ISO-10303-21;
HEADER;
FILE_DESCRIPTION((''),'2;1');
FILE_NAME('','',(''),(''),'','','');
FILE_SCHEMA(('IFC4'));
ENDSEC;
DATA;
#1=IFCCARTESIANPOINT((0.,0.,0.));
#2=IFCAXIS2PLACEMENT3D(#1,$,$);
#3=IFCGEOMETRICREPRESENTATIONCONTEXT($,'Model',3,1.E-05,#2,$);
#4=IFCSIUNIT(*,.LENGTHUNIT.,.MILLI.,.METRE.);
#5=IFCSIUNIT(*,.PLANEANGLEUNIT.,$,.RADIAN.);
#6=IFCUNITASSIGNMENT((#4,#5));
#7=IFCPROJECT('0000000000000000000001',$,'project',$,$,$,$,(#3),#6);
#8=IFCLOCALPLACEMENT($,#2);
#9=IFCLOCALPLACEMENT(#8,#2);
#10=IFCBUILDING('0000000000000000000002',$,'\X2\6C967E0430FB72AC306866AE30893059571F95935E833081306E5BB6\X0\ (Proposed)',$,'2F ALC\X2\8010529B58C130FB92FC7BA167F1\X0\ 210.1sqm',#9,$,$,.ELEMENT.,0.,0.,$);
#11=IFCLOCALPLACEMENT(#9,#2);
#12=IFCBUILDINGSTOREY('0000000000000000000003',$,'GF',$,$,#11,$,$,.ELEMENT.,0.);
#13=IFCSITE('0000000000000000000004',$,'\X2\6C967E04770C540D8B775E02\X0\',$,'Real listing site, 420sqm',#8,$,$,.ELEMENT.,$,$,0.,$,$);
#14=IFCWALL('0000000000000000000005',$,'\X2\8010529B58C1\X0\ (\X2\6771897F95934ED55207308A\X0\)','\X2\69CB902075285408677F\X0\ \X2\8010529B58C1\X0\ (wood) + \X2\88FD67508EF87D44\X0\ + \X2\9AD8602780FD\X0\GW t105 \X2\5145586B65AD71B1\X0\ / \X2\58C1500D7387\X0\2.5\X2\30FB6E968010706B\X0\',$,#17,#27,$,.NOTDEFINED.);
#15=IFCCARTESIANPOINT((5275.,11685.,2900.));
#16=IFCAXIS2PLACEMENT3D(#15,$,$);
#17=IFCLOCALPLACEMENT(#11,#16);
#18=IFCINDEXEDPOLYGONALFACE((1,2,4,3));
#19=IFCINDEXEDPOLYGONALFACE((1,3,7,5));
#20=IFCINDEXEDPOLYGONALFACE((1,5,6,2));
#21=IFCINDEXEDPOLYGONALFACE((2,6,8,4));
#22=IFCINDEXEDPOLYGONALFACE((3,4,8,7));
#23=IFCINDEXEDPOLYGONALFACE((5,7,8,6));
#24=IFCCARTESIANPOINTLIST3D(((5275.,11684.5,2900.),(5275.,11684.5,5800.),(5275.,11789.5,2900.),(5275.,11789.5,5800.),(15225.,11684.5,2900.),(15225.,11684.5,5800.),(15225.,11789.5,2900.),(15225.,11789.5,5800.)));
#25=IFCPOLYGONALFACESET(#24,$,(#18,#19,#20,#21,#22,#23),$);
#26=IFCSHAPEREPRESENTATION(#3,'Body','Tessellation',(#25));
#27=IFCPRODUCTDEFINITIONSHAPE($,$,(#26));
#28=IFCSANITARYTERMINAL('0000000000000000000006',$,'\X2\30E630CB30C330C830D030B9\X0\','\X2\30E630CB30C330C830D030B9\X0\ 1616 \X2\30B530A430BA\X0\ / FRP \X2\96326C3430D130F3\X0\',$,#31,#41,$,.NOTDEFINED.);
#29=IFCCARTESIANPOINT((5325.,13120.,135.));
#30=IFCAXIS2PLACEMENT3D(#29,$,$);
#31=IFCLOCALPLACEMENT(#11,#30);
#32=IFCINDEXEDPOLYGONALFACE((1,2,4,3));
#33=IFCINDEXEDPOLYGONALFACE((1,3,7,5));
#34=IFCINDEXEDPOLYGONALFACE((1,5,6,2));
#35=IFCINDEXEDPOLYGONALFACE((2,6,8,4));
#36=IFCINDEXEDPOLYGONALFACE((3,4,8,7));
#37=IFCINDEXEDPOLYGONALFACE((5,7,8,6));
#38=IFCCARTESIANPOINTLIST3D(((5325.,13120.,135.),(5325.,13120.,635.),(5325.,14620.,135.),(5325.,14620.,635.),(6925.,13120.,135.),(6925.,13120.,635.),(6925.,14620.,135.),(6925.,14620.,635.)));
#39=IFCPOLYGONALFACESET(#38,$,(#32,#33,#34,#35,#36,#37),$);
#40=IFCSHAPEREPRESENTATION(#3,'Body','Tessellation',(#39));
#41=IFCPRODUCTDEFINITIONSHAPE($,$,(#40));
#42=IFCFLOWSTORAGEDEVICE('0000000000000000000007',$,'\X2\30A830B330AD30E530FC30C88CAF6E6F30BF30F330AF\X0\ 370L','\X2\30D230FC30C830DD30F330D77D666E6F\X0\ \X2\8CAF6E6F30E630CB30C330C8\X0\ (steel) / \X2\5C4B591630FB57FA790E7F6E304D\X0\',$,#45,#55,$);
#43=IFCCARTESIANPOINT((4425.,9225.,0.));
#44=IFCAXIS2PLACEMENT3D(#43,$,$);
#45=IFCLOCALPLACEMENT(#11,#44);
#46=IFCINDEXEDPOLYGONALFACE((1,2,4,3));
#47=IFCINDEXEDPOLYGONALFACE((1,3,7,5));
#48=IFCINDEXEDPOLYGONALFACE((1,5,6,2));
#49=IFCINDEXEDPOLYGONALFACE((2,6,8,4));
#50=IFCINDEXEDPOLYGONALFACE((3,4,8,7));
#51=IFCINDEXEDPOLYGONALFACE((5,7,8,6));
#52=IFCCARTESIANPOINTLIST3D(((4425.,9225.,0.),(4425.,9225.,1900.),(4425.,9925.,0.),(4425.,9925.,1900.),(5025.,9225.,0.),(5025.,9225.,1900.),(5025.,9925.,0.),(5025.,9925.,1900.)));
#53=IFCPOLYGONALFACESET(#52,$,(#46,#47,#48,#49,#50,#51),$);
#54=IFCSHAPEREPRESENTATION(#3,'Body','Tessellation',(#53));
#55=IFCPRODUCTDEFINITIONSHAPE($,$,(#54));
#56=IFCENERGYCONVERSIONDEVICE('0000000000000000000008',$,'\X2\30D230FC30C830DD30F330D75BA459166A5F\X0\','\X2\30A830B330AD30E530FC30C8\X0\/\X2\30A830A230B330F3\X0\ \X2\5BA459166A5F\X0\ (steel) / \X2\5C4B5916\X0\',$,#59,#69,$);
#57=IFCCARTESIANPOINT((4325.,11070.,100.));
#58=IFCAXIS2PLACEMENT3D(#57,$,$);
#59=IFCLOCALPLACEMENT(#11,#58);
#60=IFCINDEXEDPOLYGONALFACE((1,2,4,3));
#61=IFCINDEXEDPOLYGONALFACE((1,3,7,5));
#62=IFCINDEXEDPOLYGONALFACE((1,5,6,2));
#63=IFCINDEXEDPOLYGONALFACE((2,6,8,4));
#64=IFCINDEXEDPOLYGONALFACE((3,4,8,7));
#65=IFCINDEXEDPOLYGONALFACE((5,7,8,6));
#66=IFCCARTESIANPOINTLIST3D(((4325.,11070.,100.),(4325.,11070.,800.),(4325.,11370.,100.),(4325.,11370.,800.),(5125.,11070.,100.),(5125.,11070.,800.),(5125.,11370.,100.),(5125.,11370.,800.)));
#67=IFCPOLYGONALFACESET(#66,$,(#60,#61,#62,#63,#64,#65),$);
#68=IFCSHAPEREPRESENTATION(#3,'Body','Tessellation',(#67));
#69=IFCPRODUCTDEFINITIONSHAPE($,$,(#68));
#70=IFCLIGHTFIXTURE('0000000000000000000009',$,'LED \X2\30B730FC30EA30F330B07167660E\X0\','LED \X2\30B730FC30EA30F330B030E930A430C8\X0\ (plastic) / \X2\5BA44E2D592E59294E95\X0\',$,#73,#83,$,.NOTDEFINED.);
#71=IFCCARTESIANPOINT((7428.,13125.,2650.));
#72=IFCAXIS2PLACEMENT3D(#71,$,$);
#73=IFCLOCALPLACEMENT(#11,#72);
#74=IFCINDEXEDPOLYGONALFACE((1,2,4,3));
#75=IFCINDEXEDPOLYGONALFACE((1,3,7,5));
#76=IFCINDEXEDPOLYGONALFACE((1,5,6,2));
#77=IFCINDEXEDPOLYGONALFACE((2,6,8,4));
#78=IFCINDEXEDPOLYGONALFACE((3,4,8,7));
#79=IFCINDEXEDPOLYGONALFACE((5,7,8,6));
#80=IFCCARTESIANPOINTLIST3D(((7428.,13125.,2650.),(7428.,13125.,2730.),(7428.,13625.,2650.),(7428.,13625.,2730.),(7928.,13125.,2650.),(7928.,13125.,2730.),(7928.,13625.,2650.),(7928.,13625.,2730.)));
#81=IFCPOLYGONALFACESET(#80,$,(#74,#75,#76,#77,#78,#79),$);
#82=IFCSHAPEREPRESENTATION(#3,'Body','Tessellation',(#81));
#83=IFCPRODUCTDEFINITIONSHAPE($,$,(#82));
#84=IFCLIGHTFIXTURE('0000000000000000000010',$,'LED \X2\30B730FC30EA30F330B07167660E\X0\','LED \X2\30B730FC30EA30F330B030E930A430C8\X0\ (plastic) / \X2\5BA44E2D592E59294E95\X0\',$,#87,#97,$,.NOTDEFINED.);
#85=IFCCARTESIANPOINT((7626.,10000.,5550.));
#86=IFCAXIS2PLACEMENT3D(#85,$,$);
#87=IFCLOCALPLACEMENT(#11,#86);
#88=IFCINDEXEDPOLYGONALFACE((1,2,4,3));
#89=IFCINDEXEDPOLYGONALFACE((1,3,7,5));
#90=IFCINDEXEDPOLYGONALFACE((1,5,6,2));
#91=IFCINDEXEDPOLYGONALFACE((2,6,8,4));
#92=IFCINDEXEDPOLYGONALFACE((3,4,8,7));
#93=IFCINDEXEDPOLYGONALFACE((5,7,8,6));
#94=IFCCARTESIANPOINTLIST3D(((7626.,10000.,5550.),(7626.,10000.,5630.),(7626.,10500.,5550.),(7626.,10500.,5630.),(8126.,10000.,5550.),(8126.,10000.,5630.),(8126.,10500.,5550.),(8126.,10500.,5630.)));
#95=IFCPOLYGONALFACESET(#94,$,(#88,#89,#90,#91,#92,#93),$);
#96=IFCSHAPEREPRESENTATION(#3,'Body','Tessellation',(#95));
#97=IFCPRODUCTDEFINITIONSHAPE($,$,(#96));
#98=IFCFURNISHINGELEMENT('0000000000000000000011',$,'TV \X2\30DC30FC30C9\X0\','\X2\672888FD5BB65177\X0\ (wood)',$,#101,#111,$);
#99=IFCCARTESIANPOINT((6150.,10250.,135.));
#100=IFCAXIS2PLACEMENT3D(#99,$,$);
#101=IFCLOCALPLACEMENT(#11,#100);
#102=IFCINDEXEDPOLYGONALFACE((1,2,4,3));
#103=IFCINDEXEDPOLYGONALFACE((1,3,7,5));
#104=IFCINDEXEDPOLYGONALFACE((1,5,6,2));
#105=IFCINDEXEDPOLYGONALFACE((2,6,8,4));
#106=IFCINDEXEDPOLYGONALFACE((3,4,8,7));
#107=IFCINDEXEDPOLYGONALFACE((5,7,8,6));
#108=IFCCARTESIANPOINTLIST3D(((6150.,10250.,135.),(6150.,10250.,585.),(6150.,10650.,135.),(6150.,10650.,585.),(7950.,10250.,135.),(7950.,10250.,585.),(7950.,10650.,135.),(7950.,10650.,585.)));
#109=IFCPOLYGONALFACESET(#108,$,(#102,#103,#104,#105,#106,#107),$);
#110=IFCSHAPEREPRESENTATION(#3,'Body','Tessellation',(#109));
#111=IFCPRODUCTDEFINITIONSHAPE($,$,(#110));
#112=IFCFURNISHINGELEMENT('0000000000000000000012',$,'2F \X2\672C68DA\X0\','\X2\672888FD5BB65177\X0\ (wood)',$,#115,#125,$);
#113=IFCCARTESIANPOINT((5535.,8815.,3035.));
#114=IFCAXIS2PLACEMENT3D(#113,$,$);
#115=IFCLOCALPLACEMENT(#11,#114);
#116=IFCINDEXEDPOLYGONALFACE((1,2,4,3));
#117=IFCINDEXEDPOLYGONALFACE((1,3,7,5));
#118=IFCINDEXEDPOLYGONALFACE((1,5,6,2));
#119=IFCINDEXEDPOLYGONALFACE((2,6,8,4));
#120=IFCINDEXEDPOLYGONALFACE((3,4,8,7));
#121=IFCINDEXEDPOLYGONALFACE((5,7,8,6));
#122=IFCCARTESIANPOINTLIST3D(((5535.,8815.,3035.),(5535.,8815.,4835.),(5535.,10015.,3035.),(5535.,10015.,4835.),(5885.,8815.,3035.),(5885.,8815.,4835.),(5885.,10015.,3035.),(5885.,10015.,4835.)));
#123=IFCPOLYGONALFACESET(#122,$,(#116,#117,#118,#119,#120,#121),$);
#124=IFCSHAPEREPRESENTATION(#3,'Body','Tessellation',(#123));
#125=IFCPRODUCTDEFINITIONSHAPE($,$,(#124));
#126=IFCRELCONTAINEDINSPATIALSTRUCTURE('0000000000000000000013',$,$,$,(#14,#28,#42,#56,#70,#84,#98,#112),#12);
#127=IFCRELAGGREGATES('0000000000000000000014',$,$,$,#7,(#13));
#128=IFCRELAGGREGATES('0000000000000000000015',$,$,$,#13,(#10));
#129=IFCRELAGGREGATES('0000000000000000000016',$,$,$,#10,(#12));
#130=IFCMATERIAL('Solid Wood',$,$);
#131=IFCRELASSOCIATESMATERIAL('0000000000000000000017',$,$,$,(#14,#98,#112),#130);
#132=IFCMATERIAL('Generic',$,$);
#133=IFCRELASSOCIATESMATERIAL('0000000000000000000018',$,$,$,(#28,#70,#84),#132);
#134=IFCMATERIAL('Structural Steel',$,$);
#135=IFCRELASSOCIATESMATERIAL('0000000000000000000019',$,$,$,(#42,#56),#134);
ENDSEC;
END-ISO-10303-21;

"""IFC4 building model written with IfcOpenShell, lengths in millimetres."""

from ifc_helpers import new_model, si_unit, frame, frame_2d, origin, place, context, project, spatial, rectangle, extrude, material, element, save


model = new_model("IFC4")

# Units and contexts
model_context = context("Model", 3, precision=1e-05, world=origin())
ifc_project = project(units=[si_unit("LENGTHUNIT", "METRE", prefix="MILLI"), si_unit("PLANEANGLEUNIT", "RADIAN")], contexts=[model_context])

# Site, building, storey
site_placement = place(None, origin())
site = spatial("IfcSite", under=ifc_project, at=site_placement, Name="沖縄県名護市", ObjectType="Real listing site, 420sqm", CompositionType="ELEMENT", RefElevation=0.0)
building_placement = place(site_placement, origin())
building = spatial("IfcBuilding", under=site, at=building_placement, Name="沖縄・犬と暮らす土間広めの家 (Proposed)", ObjectType="2F ALC耐力壁・鋼管柱 210.1sqm", CompositionType="ELEMENT", ElevationOfRefHeight=0.0, ElevationOfTerrain=0.0)
storey_placement = place(building_placement, origin())
storey = spatial("IfcBuildingStorey", under=building, at=storey_placement, Name="GF", CompositionType="ELEMENT", Elevation=0.0)

# Shared definitions
ifc_material_1 = material(Name="Solid Wood")

# Wall
wall_1_placement = place(storey_placement, frame((5275.0, 11685.0, 2900.0)))
element("IfcWall", 1, at=wall_1_placement, inside=storey, material=ifc_material_1, Name="耐力壁 (東西間仕切り)", Description="構造用合板 耐力壁 (wood) + 製材軸組 + 高性能GW t105 充填断熱 / 壁倍率2.5・準耐火", PredefinedType="NOTDEFINED", context=model_context, shape_type="SweptSolid", body=[
    extrude(rectangle(XDim=9950.0, YDim=105.0, at=frame_2d((4975.0, 52.0))), frame((5275.0, 11685.0, 2900.0)), (0.0, 0.0, 1.0), 2900.0),
])

# Sanitary terminal
ifc_material_2 = material(Name="Generic")
sanitary_terminal_placement = place(storey_placement, frame((5325.0, 13120.0, 135.0)))
element("IfcSanitaryTerminal", 2, at=sanitary_terminal_placement, inside=storey, material=ifc_material_2, Name="ユニットバス", Description="ユニットバス 1616 サイズ / FRP 防水パン", PredefinedType="NOTDEFINED", context=model_context, shape_type="SweptSolid", body=[
    extrude(rectangle(XDim=1600.0, YDim=1500.0, at=frame_2d((800.0, 750.0))), frame((5325.0, 13120.0, 135.0)), (0.0, 0.0, 1.0), 500.0),
])

# Flow storage device
ifc_material_3 = material(Name="Structural Steel")
flow_storage_device_placement = place(storey_placement, frame((4425.0, 9225.0, 0.0)))
element("IfcFlowStorageDevice", 3, at=flow_storage_device_placement, inside=storey, material=ifc_material_3, Name="エコキュート貯湯タンク 370L", Description="ヒートポンプ給湯 貯湯ユニット (steel) / 屋外・基礎置き", context=model_context, shape_type="SweptSolid", body=[
    extrude(rectangle(XDim=600.0, YDim=700.0, at=frame_2d((300.0, 350.0))), frame((4425.0, 9225.0, 0.0)), (0.0, 0.0, 1.0), 1900.0),
])

# Energy conversion device
energy_conversion_device_placement = place(storey_placement, frame((4325.0, 11070.0, 100.0)))
element("IfcEnergyConversionDevice", 4, at=energy_conversion_device_placement, inside=storey, material=ifc_material_3, Name="ヒートポンプ室外機", Description="エコキュート/エアコン 室外機 (steel) / 屋外", context=model_context, shape_type="SweptSolid", body=[
    extrude(rectangle(XDim=800.0, YDim=300.0, at=frame_2d((400.0, 150.0))), frame((4325.0, 11070.0, 100.0)), (0.0, 0.0, 1.0), 700.0),
])

# Light fixtures
light_fixture_1_placement = place(storey_placement, frame((7428.0, 13125.0, 2650.0)))
element("IfcLightFixture", 5, at=light_fixture_1_placement, inside=storey, material=ifc_material_2, Name="LED シーリング照明", Description="LED シーリングライト (plastic) / 室中央天井", PredefinedType="NOTDEFINED", context=model_context, shape_type="SweptSolid", body=[
    extrude(rectangle(XDim=500.0, YDim=500.0, at=frame_2d((250.0, 250.0))), frame((7428.0, 13125.0, 2650.0)), (0.0, 0.0, 1.0), 80.0),
])
light_fixture_2_placement = place(storey_placement, frame((7626.0, 10000.0, 5550.0)))
element("IfcLightFixture", 6, at=light_fixture_2_placement, inside=storey, material=ifc_material_2, Name="LED シーリング照明", Description="LED シーリングライト (plastic) / 室中央天井", PredefinedType="NOTDEFINED", context=model_context, shape_type="SweptSolid", body=[
    extrude(rectangle(XDim=500.0, YDim=500.0, at=frame_2d((250.0, 250.0))), frame((7626.0, 10000.0, 5550.0)), (0.0, 0.0, 1.0), 80.0),
])

# Furnishing elements
furnishing_1_placement = place(storey_placement, frame((6150.0, 10250.0, 135.0)))
element("IfcFurnishingElement", 7, at=furnishing_1_placement, inside=storey, material=ifc_material_1, Name="TV ボード", Description="木製家具 (wood)", context=model_context, shape_type="SweptSolid", body=[
    extrude(rectangle(XDim=1800.0, YDim=400.0, at=frame_2d((900.0, 200.0))), frame((6150.0, 10250.0, 135.0)), (0.0, 0.0, 1.0), 450.0),
])
furnishing_2_placement = place(storey_placement, frame((5535.0, 8815.0, 3035.0)))
element("IfcFurnishingElement", 8, at=furnishing_2_placement, inside=storey, material=ifc_material_1, Name="2F 本棚", Description="木製家具 (wood)", context=model_context, shape_type="SweptSolid", body=[
    extrude(rectangle(XDim=350.0, YDim=1200.0, at=frame_2d((175.0, 600.0))), frame((5535.0, 8815.0, 3035.0)), (0.0, 0.0, 1.0), 1800.0),
])

save(model, "model.ifc")
